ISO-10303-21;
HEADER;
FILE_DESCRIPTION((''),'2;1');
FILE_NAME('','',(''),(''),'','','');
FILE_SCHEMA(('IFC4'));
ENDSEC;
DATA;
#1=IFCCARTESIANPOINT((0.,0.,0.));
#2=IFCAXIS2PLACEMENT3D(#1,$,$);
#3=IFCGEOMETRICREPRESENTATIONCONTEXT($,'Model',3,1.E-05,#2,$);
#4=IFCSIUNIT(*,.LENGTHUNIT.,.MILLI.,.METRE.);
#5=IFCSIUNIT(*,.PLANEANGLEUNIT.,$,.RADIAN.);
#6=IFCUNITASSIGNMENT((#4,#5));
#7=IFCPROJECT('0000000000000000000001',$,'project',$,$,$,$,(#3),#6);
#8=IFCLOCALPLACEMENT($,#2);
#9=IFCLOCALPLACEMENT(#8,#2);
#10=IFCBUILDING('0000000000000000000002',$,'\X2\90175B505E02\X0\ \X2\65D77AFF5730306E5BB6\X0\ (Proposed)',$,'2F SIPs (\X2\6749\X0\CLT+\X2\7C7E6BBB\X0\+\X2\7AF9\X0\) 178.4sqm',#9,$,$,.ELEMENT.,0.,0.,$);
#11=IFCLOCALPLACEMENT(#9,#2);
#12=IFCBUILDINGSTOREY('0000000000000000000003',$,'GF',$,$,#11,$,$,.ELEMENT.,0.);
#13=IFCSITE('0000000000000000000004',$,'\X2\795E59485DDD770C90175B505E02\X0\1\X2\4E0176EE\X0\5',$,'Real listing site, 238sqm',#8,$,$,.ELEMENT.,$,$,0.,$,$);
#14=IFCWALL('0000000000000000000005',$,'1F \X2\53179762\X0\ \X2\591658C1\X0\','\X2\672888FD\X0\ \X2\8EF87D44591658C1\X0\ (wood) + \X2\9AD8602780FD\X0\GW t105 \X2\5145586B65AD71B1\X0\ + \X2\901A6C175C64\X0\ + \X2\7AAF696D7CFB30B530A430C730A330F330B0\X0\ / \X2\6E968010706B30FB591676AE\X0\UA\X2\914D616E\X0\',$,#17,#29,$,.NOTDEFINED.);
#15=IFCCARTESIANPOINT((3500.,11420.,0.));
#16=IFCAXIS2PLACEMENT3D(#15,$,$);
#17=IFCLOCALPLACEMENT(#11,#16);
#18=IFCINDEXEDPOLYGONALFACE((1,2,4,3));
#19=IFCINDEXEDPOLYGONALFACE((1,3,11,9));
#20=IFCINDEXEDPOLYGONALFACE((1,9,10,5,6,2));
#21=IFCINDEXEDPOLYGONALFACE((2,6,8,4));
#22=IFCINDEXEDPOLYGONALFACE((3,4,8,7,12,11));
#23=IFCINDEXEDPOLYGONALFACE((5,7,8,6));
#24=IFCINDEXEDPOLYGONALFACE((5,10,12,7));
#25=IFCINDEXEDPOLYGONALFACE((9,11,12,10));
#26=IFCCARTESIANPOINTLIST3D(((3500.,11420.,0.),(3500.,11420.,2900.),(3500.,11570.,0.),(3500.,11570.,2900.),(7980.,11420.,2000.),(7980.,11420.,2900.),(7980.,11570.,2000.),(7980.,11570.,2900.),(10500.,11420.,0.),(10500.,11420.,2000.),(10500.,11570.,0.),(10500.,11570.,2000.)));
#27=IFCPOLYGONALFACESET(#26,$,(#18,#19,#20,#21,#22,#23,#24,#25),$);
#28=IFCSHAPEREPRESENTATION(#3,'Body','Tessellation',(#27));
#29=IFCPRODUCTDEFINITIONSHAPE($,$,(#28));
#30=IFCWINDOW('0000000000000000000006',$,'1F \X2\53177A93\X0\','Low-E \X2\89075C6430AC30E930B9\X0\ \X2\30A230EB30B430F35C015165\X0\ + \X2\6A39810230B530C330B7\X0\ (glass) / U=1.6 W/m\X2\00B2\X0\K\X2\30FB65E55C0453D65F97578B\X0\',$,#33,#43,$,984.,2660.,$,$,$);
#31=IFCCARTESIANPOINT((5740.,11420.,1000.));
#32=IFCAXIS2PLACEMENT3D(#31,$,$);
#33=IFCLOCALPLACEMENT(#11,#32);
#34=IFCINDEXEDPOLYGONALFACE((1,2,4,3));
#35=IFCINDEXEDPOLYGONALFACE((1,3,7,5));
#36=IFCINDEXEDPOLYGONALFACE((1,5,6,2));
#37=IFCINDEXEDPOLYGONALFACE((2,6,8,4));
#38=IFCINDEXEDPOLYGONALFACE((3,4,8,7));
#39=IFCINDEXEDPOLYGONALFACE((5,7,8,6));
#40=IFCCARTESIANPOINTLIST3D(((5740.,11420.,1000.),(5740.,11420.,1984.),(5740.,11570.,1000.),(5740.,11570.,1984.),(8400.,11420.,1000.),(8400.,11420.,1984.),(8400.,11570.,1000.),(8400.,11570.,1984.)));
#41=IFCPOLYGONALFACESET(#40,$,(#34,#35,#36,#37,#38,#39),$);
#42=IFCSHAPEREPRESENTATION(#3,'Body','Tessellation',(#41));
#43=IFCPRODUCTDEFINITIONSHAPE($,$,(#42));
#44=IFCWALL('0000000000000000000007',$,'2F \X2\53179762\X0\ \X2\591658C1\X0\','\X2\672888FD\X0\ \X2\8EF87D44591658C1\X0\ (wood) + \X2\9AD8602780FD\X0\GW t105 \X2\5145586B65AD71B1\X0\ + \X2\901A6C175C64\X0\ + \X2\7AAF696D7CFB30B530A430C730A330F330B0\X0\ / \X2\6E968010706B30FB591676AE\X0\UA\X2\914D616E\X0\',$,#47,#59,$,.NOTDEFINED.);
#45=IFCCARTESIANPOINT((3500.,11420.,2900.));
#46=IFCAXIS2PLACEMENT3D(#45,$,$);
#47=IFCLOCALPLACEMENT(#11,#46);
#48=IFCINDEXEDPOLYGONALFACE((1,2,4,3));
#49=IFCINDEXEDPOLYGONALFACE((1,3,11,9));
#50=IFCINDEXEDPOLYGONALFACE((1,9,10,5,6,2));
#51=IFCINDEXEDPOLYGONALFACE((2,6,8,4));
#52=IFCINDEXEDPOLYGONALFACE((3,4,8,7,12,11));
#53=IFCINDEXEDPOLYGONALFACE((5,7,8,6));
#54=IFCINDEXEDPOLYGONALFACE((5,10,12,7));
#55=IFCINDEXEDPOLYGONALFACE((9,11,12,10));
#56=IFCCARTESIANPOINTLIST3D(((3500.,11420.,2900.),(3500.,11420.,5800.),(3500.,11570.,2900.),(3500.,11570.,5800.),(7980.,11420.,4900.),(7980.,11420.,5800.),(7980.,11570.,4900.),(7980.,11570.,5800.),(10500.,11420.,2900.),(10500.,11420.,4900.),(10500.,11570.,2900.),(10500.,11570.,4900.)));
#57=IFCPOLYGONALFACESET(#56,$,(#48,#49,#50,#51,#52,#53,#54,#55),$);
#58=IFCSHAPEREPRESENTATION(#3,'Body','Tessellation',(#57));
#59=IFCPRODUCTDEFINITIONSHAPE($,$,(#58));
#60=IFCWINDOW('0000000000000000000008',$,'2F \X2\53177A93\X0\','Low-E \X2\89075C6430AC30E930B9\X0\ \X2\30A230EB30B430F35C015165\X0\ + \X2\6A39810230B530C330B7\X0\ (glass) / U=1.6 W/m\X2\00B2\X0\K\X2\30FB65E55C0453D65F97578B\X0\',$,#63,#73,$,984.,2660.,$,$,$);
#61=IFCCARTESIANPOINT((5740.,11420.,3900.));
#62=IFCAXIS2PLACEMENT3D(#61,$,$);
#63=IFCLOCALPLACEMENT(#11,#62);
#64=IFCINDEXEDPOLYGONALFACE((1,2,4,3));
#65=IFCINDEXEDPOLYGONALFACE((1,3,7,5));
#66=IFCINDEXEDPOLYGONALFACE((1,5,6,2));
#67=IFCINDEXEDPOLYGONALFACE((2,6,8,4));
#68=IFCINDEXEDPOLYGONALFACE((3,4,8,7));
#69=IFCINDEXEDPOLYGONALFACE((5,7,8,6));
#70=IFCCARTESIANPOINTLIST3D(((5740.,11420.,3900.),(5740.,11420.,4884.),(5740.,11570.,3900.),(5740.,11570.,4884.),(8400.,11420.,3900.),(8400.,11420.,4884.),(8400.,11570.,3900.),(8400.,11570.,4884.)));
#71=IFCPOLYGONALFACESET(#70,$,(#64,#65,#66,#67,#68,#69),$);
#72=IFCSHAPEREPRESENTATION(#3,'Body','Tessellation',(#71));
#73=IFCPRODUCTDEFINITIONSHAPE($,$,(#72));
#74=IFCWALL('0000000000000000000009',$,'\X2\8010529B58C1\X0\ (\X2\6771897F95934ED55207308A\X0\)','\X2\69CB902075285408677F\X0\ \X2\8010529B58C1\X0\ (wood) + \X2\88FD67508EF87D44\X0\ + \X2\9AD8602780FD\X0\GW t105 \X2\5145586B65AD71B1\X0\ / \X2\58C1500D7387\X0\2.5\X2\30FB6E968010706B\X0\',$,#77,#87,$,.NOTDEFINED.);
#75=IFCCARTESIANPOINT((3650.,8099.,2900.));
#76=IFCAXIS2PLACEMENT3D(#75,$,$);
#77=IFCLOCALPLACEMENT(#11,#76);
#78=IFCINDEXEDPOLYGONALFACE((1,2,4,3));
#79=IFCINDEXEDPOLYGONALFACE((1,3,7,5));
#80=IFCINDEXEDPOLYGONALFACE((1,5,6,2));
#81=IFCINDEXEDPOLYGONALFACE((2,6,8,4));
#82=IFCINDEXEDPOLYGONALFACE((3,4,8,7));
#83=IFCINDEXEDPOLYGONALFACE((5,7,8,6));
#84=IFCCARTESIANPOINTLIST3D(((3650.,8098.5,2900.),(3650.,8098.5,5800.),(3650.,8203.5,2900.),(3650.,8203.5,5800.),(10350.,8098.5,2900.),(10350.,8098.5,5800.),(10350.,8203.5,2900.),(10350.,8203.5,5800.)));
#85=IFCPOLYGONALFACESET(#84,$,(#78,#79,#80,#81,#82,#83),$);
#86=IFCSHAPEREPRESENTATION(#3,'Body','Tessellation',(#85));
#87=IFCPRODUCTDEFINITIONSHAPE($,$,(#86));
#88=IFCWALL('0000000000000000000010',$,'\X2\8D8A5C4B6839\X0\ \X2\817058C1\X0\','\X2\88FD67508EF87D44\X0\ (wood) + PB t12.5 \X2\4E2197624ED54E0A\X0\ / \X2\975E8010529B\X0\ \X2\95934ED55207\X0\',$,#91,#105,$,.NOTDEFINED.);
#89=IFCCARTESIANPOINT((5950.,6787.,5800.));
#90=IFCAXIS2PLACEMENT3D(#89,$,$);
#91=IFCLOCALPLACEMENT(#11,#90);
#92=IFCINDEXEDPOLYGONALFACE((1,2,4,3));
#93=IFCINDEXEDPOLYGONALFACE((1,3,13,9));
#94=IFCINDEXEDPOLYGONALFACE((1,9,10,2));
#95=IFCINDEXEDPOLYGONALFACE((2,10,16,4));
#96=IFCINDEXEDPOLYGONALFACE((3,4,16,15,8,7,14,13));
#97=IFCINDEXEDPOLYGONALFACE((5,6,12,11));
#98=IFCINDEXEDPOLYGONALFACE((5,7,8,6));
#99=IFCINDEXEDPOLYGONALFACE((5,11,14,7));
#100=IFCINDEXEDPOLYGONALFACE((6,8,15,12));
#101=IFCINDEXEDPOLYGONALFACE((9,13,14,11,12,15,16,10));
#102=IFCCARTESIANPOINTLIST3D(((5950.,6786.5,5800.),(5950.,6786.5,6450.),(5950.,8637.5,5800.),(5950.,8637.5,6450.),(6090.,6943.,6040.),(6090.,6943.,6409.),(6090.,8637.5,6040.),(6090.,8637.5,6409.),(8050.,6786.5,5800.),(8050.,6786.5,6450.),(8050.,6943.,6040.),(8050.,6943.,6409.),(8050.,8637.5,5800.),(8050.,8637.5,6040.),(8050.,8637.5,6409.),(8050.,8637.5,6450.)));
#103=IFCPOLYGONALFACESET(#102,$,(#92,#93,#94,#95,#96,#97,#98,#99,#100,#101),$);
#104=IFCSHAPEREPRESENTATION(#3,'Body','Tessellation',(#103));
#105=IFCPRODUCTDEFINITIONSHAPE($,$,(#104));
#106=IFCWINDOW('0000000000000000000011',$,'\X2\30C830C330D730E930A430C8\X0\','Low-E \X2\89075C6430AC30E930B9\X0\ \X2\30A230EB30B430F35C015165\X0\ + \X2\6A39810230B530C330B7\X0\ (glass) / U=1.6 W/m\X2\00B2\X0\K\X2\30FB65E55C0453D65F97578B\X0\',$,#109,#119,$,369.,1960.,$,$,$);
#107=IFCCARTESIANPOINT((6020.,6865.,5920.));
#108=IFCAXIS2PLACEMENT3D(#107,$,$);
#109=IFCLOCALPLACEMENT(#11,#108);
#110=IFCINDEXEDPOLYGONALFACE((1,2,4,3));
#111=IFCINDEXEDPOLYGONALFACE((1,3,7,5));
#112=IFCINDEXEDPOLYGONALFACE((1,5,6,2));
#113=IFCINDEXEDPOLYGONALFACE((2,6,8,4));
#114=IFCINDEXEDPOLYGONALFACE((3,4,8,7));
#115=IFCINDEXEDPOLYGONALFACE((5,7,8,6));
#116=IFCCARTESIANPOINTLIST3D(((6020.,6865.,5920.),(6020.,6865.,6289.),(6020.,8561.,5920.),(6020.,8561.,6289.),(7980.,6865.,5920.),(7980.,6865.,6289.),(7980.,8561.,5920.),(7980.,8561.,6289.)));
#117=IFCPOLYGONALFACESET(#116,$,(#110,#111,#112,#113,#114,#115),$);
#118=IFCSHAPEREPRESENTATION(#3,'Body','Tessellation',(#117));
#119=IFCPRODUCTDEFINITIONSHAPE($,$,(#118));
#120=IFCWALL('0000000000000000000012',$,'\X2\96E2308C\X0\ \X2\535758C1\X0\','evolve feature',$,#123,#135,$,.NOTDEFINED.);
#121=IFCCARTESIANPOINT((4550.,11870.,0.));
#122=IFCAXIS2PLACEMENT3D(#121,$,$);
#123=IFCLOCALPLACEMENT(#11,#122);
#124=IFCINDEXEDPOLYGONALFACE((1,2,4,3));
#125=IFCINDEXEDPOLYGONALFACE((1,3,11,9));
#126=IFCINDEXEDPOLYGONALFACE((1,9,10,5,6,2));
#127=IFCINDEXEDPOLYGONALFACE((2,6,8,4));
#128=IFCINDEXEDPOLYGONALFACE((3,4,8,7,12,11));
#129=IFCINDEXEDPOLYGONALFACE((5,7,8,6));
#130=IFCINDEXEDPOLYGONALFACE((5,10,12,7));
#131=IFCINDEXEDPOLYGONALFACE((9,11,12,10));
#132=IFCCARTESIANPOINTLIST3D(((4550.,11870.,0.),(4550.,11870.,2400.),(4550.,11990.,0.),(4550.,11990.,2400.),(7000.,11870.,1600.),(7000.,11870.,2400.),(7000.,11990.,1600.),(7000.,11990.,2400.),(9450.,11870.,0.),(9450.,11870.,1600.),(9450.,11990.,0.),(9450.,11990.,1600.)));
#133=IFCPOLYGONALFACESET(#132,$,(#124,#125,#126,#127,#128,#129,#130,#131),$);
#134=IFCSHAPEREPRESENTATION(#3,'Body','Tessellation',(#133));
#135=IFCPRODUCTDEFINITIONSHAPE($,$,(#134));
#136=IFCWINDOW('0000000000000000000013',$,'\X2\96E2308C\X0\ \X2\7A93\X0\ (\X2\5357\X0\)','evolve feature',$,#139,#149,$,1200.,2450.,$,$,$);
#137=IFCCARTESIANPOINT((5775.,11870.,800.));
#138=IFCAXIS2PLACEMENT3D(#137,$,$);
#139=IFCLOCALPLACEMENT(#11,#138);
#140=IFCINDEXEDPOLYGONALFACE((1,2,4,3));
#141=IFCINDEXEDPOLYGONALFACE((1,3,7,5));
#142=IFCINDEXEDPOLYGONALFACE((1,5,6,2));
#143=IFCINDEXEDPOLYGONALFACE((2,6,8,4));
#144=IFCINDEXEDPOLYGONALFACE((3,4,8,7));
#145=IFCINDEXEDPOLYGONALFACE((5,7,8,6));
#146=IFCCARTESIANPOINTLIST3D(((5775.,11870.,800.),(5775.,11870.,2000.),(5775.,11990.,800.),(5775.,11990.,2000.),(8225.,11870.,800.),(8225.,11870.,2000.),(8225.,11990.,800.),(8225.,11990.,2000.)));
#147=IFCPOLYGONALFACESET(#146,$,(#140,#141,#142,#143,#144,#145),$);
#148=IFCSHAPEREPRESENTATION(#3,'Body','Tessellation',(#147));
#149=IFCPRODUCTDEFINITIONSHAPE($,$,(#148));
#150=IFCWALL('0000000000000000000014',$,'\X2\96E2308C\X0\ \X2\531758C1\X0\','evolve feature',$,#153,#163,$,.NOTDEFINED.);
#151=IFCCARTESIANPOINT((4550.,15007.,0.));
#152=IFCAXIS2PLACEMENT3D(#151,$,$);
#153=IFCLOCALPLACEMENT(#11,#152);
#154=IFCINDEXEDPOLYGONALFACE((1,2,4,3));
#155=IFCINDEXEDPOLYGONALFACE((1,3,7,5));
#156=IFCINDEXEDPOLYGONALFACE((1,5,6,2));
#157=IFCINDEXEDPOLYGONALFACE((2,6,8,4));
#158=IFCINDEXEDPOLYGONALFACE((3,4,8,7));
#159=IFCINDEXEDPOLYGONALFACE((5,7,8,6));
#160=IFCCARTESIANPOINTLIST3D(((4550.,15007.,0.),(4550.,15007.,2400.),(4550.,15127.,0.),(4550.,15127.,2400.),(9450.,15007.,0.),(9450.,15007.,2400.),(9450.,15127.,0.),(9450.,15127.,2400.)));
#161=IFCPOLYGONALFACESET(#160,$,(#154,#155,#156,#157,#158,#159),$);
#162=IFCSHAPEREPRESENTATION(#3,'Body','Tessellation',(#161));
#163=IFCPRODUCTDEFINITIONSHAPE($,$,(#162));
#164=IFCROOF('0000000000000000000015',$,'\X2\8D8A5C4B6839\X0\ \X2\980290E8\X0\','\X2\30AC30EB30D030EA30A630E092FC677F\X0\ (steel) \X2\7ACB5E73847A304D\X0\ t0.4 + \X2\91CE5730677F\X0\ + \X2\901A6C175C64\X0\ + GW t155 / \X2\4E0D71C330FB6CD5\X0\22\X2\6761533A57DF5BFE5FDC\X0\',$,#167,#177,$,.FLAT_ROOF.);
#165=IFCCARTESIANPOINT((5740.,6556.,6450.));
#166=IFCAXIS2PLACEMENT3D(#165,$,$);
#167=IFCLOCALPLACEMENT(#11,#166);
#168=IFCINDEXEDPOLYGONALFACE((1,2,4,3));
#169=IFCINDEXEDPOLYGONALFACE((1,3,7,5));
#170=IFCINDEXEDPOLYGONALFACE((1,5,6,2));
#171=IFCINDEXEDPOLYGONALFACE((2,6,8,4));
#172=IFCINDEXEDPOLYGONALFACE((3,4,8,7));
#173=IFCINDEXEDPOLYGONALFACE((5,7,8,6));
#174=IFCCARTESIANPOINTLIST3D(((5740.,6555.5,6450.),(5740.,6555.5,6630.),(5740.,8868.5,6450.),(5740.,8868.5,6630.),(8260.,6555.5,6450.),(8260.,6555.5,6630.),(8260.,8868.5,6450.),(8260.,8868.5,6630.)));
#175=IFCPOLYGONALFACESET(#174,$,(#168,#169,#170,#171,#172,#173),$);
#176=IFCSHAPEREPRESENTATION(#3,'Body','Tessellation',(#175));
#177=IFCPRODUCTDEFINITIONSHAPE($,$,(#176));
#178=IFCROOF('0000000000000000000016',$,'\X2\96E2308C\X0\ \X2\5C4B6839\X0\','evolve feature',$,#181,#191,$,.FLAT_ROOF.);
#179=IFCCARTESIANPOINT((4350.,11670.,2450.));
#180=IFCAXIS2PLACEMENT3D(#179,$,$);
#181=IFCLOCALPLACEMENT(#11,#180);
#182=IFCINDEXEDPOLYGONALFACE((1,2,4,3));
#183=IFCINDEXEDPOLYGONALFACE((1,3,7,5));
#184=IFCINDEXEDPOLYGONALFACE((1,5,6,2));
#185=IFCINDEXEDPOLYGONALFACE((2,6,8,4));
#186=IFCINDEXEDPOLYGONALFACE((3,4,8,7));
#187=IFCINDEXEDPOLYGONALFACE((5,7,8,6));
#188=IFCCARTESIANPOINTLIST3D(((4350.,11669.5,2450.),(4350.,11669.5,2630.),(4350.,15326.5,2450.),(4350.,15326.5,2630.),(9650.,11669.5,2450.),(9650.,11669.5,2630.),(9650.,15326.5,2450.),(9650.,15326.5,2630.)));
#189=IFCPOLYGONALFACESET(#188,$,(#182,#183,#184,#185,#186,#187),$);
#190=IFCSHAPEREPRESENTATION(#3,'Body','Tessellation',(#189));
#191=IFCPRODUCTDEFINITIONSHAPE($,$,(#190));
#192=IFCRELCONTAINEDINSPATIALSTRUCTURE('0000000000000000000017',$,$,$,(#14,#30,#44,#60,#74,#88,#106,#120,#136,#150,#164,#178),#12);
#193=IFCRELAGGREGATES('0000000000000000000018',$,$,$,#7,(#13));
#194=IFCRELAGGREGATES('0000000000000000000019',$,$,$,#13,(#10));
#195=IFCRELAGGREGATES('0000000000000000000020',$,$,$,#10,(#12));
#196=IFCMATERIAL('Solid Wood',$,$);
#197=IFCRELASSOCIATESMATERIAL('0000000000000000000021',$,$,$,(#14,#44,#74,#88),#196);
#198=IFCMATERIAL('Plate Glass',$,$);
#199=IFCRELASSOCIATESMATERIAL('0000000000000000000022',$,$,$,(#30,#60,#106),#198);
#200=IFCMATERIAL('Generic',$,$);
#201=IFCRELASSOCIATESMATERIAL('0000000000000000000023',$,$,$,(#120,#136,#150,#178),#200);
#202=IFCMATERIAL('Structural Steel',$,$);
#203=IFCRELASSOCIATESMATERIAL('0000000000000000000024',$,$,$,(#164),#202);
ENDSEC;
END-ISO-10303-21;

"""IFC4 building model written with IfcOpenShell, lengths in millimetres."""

from ifc_helpers import new_model, si_unit, frame, frame_2d, origin, place, context, project, spatial, rectangle, extrude, material, element, fill, save


model = new_model("IFC4")

# Units and contexts
model_context = context("Model", 3, precision=1e-05, world=origin())
ifc_project = project(units=[si_unit("LENGTHUNIT", "METRE", prefix="MILLI"), si_unit("PLANEANGLEUNIT", "RADIAN")], contexts=[model_context])

# Site, building, storey
site_placement = place(None, origin())
site = spatial("IfcSite", under=ifc_project, at=site_placement, Name="神奈川県逗子市1丁目5", ObjectType="Real listing site, 238sqm", CompositionType="ELEMENT", RefElevation=0.0)
building_placement = place(site_placement, origin())
building = spatial("IfcBuilding", under=site, at=building_placement, Name="逗子市 旗竿地の家 (Proposed)", ObjectType="2F SIPs (杉CLT+籾殻+竹) 178.4sqm", CompositionType="ELEMENT", ElevationOfRefHeight=0.0, ElevationOfTerrain=0.0)
storey_placement = place(building_placement, origin())
storey = spatial("IfcBuildingStorey", under=building, at=storey_placement, Name="GF", CompositionType="ELEMENT", Elevation=0.0)

# Shared definitions
ifc_material_1 = material(Name="Generic")

# Wall, opening, window
ifc_material_2 = material(Name="Solid Wood")
wall_1_placement = place(storey_placement, frame((3500.0, 11420.0, 0.0)))
wall_1 = element("IfcWall", 1, at=wall_1_placement, inside=storey, material=ifc_material_2, Name="1F 北面 外壁", Description="木製 軸組外壁 (wood) + 高性能GW t105 充填断熱 + 通気層 + 窯業系サイディング / 準耐火・外皮UA配慮", PredefinedType="NOTDEFINED", context=model_context, shape_type="SweptSolid", body=[
    extrude(rectangle(XDim=7000.0, YDim=150.0, at=frame_2d((3500.0, 75.0))), frame((3500.0, 11420.0, 0.0)), (0.0, 0.0, 1.0), 2900.0),
])
opening_1_placement = place(storey_placement, frame((5740.0, 11420.0, 1000.0)))
opening_1 = element("IfcOpeningElement", 2, at=opening_1_placement, cuts=wall_1, PredefinedType="NOTDEFINED", context=model_context, shape_type="SweptSolid", body=[
    extrude(rectangle(XDim=2660.0, YDim=150.0, at=frame_2d((1330.0, 75.0))), frame((5740.0, 11420.0, 1000.0)), (0.0, 0.0, 1.0), 984.0),
])
ifc_material_3 = material(Name="Plate Glass")
window_1_placement = place(storey_placement, frame((5740.0, 11420.0, 1000.0)))
window_1 = element("IfcWindow", 3, at=window_1_placement, inside=storey, material=ifc_material_3, Name="1F 北窓", Description="Low-E 複層ガラス アルゴン封入 + 樹脂サッシ (glass) / U=1.6 W/m²K・日射取得型", OverallHeight=984.0, OverallWidth=2660.0, context=model_context, shape_type="SweptSolid", body=[
    extrude(rectangle(XDim=2660.0, YDim=150.0, at=frame_2d((1330.0, 75.0))), frame((5740.0, 11420.0, 1000.0)), (0.0, 0.0, 1.0), 984.0),
])
fill(opening_1, window_1)

# Wall, opening, window
wall_2_placement = place(storey_placement, frame((3500.0, 11420.0, 2900.0)))
wall_2 = element("IfcWall", 4, at=wall_2_placement, inside=storey, material=ifc_material_2, Name="2F 北面 外壁", Description="木製 軸組外壁 (wood) + 高性能GW t105 充填断熱 + 通気層 + 窯業系サイディング / 準耐火・外皮UA配慮", PredefinedType="NOTDEFINED", context=model_context, shape_type="SweptSolid", body=[
    extrude(rectangle(XDim=7000.0, YDim=150.0, at=frame_2d((3500.0, 75.0))), frame((3500.0, 11420.0, 2900.0)), (0.0, 0.0, 1.0), 2900.0),
])
opening_2_placement = place(storey_placement, frame((5740.0, 11420.0, 3900.0)))
opening_2 = element("IfcOpeningElement", 5, at=opening_2_placement, cuts=wall_2, PredefinedType="NOTDEFINED", context=model_context, shape_type="SweptSolid", body=[
    extrude(rectangle(XDim=2660.0, YDim=150.0, at=frame_2d((1330.0, 75.0))), frame((5740.0, 11420.0, 3900.0)), (0.0, 0.0, 1.0), 984.0),
])
window_2_placement = place(storey_placement, frame((5740.0, 11420.0, 3900.0)))
window_2 = element("IfcWindow", 6, at=window_2_placement, inside=storey, material=ifc_material_3, Name="2F 北窓", Description="Low-E 複層ガラス アルゴン封入 + 樹脂サッシ (glass) / U=1.6 W/m²K・日射取得型", OverallHeight=984.0, OverallWidth=2660.0, context=model_context, shape_type="SweptSolid", body=[
    extrude(rectangle(XDim=2660.0, YDim=150.0, at=frame_2d((1330.0, 75.0))), frame((5740.0, 11420.0, 3900.0)), (0.0, 0.0, 1.0), 984.0),
])
fill(opening_2, window_2)

# Wall
wall_3_placement = place(storey_placement, frame((3650.0, 8099.0, 2900.0)))
element("IfcWall", 7, at=wall_3_placement, inside=storey, material=ifc_material_2, Name="耐力壁 (東西間仕切り)", Description="構造用合板 耐力壁 (wood) + 製材軸組 + 高性能GW t105 充填断熱 / 壁倍率2.5・準耐火", PredefinedType="NOTDEFINED", context=model_context, shape_type="SweptSolid", body=[
    extrude(rectangle(XDim=6700.0, YDim=105.0, at=frame_2d((3350.0, 52.0))), frame((3650.0, 8099.0, 2900.0)), (0.0, 0.0, 1.0), 2900.0),
])

# Walls, openings, windows
wall_4_placement = place(storey_placement, frame((5950.0, 6787.0, 5800.0)))
wall_4 = element("IfcWall", 8, at=wall_4_placement, inside=storey, material=ifc_material_2, Name="越屋根 腰壁", Description="製材軸組 (wood) + PB t12.5 両面仕上 / 非耐力 間仕切", PredefinedType="NOTDEFINED", context=model_context, shape_type="SweptSolid", body=[
    extrude(rectangle(XDim=2100.0, YDim=1851.0, at=frame_2d((1050.0, 925.0))), frame((5950.0, 6787.0, 5800.0)), (0.0, 0.0, 1.0), 650.0),
])
opening_3_placement = place(storey_placement, frame((6020.0, 6865.0, 5920.0)))
opening_3 = element("IfcOpeningElement", 9, at=opening_3_placement, cuts=wall_4, PredefinedType="NOTDEFINED", context=model_context, shape_type="SweptSolid", body=[
    extrude(rectangle(XDim=1960.0, YDim=1696.0, at=frame_2d((980.0, 848.0))), frame((6020.0, 6865.0, 5920.0)), (0.0, 0.0, 1.0), 369.0),
])
window_3_placement = place(storey_placement, frame((6020.0, 6865.0, 5920.0)))
window_3 = element("IfcWindow", 10, at=window_3_placement, inside=storey, material=ifc_material_3, Name="トップライト", Description="Low-E 複層ガラス アルゴン封入 + 樹脂サッシ (glass) / U=1.6 W/m²K・日射取得型", OverallHeight=369.0, OverallWidth=1960.0, context=model_context, shape_type="SweptSolid", body=[
    extrude(rectangle(XDim=1960.0, YDim=1696.0, at=frame_2d((980.0, 848.0))), frame((6020.0, 6865.0, 5920.0)), (0.0, 0.0, 1.0), 369.0),
])
fill(opening_3, window_3)
wall_5_placement = place(storey_placement, frame((4550.0, 11870.0, 0.0)))
wall_5 = element("IfcWall", 11, at=wall_5_placement, inside=storey, material=ifc_material_1, Name="離れ 南壁", Description="evolve feature", PredefinedType="NOTDEFINED", context=model_context, shape_type="SweptSolid", body=[
    extrude(rectangle(XDim=4900.0, YDim=120.0, at=frame_2d((2450.0, 60.0))), frame((4550.0, 11870.0, 0.0)), (0.0, 0.0, 1.0), 2400.0),
])
opening_4_placement = place(storey_placement, frame((5775.0, 11870.0, 800.0)))
opening_4 = element("IfcOpeningElement", 12, at=opening_4_placement, cuts=wall_5, PredefinedType="NOTDEFINED", context=model_context, shape_type="SweptSolid", body=[
    extrude(rectangle(XDim=2450.0, YDim=120.0, at=frame_2d((1225.0, 60.0))), frame((5775.0, 11870.0, 800.0)), (0.0, 0.0, 1.0), 1200.0),
])
window_4_placement = place(storey_placement, frame((5775.0, 11870.0, 800.0)))
window_4 = element("IfcWindow", 13, at=window_4_placement, inside=storey, material=ifc_material_1, Name="離れ 窓 (南)", Description="evolve feature", OverallHeight=1200.0, OverallWidth=2450.0, context=model_context, shape_type="SweptSolid", body=[
    extrude(rectangle(XDim=2450.0, YDim=120.0, at=frame_2d((1225.0, 60.0))), frame((5775.0, 11870.0, 800.0)), (0.0, 0.0, 1.0), 1200.0),
])
fill(opening_4, window_4)

# Wall
wall_6_placement = place(storey_placement, frame((4550.0, 15007.0, 0.0)))
element("IfcWall", 14, at=wall_6_placement, inside=storey, material=ifc_material_1, Name="離れ 北壁", Description="evolve feature", PredefinedType="NOTDEFINED", context=model_context, shape_type="SweptSolid", body=[
    extrude(rectangle(XDim=4900.0, YDim=120.0, at=frame_2d((2450.0, 60.0))), frame((4550.0, 15007.0, 0.0)), (0.0, 0.0, 1.0), 2400.0),
])

# Roofs
ifc_material_4 = material(Name="Structural Steel")
roof_1_placement = place(storey_placement, frame((5740.0, 6556.0, 6450.0)))
element("IfcRoof", 15, at=roof_1_placement, inside=storey, material=ifc_material_4, Name="越屋根 頂部", Description="ガルバリウム鋼板 (steel) 立平葺き t0.4 + 野地板 + 通気層 + GW t155 / 不燃・法22条区域対応", PredefinedType="FLAT_ROOF", context=model_context, shape_type="SweptSolid", body=[
    extrude(rectangle(XDim=2520.0, YDim=2313.0, at=frame_2d((1260.0, 1156.0))), frame((5740.0, 6556.0, 6450.0)), (0.0, 0.0, 1.0), 180.0),
])
roof_2_placement = place(storey_placement, frame((4350.0, 11670.0, 2450.0)))
element("IfcRoof", 16, at=roof_2_placement, inside=storey, material=ifc_material_1, Name="離れ 屋根", Description="evolve feature", PredefinedType="FLAT_ROOF", context=model_context, shape_type="SweptSolid", body=[
    extrude(rectangle(XDim=5300.0, YDim=3657.0, at=frame_2d((2650.0, 1828.0))), frame((4350.0, 11670.0, 2450.0)), (0.0, 0.0, 1.0), 180.0),
])

save(model, "model.ifc")
